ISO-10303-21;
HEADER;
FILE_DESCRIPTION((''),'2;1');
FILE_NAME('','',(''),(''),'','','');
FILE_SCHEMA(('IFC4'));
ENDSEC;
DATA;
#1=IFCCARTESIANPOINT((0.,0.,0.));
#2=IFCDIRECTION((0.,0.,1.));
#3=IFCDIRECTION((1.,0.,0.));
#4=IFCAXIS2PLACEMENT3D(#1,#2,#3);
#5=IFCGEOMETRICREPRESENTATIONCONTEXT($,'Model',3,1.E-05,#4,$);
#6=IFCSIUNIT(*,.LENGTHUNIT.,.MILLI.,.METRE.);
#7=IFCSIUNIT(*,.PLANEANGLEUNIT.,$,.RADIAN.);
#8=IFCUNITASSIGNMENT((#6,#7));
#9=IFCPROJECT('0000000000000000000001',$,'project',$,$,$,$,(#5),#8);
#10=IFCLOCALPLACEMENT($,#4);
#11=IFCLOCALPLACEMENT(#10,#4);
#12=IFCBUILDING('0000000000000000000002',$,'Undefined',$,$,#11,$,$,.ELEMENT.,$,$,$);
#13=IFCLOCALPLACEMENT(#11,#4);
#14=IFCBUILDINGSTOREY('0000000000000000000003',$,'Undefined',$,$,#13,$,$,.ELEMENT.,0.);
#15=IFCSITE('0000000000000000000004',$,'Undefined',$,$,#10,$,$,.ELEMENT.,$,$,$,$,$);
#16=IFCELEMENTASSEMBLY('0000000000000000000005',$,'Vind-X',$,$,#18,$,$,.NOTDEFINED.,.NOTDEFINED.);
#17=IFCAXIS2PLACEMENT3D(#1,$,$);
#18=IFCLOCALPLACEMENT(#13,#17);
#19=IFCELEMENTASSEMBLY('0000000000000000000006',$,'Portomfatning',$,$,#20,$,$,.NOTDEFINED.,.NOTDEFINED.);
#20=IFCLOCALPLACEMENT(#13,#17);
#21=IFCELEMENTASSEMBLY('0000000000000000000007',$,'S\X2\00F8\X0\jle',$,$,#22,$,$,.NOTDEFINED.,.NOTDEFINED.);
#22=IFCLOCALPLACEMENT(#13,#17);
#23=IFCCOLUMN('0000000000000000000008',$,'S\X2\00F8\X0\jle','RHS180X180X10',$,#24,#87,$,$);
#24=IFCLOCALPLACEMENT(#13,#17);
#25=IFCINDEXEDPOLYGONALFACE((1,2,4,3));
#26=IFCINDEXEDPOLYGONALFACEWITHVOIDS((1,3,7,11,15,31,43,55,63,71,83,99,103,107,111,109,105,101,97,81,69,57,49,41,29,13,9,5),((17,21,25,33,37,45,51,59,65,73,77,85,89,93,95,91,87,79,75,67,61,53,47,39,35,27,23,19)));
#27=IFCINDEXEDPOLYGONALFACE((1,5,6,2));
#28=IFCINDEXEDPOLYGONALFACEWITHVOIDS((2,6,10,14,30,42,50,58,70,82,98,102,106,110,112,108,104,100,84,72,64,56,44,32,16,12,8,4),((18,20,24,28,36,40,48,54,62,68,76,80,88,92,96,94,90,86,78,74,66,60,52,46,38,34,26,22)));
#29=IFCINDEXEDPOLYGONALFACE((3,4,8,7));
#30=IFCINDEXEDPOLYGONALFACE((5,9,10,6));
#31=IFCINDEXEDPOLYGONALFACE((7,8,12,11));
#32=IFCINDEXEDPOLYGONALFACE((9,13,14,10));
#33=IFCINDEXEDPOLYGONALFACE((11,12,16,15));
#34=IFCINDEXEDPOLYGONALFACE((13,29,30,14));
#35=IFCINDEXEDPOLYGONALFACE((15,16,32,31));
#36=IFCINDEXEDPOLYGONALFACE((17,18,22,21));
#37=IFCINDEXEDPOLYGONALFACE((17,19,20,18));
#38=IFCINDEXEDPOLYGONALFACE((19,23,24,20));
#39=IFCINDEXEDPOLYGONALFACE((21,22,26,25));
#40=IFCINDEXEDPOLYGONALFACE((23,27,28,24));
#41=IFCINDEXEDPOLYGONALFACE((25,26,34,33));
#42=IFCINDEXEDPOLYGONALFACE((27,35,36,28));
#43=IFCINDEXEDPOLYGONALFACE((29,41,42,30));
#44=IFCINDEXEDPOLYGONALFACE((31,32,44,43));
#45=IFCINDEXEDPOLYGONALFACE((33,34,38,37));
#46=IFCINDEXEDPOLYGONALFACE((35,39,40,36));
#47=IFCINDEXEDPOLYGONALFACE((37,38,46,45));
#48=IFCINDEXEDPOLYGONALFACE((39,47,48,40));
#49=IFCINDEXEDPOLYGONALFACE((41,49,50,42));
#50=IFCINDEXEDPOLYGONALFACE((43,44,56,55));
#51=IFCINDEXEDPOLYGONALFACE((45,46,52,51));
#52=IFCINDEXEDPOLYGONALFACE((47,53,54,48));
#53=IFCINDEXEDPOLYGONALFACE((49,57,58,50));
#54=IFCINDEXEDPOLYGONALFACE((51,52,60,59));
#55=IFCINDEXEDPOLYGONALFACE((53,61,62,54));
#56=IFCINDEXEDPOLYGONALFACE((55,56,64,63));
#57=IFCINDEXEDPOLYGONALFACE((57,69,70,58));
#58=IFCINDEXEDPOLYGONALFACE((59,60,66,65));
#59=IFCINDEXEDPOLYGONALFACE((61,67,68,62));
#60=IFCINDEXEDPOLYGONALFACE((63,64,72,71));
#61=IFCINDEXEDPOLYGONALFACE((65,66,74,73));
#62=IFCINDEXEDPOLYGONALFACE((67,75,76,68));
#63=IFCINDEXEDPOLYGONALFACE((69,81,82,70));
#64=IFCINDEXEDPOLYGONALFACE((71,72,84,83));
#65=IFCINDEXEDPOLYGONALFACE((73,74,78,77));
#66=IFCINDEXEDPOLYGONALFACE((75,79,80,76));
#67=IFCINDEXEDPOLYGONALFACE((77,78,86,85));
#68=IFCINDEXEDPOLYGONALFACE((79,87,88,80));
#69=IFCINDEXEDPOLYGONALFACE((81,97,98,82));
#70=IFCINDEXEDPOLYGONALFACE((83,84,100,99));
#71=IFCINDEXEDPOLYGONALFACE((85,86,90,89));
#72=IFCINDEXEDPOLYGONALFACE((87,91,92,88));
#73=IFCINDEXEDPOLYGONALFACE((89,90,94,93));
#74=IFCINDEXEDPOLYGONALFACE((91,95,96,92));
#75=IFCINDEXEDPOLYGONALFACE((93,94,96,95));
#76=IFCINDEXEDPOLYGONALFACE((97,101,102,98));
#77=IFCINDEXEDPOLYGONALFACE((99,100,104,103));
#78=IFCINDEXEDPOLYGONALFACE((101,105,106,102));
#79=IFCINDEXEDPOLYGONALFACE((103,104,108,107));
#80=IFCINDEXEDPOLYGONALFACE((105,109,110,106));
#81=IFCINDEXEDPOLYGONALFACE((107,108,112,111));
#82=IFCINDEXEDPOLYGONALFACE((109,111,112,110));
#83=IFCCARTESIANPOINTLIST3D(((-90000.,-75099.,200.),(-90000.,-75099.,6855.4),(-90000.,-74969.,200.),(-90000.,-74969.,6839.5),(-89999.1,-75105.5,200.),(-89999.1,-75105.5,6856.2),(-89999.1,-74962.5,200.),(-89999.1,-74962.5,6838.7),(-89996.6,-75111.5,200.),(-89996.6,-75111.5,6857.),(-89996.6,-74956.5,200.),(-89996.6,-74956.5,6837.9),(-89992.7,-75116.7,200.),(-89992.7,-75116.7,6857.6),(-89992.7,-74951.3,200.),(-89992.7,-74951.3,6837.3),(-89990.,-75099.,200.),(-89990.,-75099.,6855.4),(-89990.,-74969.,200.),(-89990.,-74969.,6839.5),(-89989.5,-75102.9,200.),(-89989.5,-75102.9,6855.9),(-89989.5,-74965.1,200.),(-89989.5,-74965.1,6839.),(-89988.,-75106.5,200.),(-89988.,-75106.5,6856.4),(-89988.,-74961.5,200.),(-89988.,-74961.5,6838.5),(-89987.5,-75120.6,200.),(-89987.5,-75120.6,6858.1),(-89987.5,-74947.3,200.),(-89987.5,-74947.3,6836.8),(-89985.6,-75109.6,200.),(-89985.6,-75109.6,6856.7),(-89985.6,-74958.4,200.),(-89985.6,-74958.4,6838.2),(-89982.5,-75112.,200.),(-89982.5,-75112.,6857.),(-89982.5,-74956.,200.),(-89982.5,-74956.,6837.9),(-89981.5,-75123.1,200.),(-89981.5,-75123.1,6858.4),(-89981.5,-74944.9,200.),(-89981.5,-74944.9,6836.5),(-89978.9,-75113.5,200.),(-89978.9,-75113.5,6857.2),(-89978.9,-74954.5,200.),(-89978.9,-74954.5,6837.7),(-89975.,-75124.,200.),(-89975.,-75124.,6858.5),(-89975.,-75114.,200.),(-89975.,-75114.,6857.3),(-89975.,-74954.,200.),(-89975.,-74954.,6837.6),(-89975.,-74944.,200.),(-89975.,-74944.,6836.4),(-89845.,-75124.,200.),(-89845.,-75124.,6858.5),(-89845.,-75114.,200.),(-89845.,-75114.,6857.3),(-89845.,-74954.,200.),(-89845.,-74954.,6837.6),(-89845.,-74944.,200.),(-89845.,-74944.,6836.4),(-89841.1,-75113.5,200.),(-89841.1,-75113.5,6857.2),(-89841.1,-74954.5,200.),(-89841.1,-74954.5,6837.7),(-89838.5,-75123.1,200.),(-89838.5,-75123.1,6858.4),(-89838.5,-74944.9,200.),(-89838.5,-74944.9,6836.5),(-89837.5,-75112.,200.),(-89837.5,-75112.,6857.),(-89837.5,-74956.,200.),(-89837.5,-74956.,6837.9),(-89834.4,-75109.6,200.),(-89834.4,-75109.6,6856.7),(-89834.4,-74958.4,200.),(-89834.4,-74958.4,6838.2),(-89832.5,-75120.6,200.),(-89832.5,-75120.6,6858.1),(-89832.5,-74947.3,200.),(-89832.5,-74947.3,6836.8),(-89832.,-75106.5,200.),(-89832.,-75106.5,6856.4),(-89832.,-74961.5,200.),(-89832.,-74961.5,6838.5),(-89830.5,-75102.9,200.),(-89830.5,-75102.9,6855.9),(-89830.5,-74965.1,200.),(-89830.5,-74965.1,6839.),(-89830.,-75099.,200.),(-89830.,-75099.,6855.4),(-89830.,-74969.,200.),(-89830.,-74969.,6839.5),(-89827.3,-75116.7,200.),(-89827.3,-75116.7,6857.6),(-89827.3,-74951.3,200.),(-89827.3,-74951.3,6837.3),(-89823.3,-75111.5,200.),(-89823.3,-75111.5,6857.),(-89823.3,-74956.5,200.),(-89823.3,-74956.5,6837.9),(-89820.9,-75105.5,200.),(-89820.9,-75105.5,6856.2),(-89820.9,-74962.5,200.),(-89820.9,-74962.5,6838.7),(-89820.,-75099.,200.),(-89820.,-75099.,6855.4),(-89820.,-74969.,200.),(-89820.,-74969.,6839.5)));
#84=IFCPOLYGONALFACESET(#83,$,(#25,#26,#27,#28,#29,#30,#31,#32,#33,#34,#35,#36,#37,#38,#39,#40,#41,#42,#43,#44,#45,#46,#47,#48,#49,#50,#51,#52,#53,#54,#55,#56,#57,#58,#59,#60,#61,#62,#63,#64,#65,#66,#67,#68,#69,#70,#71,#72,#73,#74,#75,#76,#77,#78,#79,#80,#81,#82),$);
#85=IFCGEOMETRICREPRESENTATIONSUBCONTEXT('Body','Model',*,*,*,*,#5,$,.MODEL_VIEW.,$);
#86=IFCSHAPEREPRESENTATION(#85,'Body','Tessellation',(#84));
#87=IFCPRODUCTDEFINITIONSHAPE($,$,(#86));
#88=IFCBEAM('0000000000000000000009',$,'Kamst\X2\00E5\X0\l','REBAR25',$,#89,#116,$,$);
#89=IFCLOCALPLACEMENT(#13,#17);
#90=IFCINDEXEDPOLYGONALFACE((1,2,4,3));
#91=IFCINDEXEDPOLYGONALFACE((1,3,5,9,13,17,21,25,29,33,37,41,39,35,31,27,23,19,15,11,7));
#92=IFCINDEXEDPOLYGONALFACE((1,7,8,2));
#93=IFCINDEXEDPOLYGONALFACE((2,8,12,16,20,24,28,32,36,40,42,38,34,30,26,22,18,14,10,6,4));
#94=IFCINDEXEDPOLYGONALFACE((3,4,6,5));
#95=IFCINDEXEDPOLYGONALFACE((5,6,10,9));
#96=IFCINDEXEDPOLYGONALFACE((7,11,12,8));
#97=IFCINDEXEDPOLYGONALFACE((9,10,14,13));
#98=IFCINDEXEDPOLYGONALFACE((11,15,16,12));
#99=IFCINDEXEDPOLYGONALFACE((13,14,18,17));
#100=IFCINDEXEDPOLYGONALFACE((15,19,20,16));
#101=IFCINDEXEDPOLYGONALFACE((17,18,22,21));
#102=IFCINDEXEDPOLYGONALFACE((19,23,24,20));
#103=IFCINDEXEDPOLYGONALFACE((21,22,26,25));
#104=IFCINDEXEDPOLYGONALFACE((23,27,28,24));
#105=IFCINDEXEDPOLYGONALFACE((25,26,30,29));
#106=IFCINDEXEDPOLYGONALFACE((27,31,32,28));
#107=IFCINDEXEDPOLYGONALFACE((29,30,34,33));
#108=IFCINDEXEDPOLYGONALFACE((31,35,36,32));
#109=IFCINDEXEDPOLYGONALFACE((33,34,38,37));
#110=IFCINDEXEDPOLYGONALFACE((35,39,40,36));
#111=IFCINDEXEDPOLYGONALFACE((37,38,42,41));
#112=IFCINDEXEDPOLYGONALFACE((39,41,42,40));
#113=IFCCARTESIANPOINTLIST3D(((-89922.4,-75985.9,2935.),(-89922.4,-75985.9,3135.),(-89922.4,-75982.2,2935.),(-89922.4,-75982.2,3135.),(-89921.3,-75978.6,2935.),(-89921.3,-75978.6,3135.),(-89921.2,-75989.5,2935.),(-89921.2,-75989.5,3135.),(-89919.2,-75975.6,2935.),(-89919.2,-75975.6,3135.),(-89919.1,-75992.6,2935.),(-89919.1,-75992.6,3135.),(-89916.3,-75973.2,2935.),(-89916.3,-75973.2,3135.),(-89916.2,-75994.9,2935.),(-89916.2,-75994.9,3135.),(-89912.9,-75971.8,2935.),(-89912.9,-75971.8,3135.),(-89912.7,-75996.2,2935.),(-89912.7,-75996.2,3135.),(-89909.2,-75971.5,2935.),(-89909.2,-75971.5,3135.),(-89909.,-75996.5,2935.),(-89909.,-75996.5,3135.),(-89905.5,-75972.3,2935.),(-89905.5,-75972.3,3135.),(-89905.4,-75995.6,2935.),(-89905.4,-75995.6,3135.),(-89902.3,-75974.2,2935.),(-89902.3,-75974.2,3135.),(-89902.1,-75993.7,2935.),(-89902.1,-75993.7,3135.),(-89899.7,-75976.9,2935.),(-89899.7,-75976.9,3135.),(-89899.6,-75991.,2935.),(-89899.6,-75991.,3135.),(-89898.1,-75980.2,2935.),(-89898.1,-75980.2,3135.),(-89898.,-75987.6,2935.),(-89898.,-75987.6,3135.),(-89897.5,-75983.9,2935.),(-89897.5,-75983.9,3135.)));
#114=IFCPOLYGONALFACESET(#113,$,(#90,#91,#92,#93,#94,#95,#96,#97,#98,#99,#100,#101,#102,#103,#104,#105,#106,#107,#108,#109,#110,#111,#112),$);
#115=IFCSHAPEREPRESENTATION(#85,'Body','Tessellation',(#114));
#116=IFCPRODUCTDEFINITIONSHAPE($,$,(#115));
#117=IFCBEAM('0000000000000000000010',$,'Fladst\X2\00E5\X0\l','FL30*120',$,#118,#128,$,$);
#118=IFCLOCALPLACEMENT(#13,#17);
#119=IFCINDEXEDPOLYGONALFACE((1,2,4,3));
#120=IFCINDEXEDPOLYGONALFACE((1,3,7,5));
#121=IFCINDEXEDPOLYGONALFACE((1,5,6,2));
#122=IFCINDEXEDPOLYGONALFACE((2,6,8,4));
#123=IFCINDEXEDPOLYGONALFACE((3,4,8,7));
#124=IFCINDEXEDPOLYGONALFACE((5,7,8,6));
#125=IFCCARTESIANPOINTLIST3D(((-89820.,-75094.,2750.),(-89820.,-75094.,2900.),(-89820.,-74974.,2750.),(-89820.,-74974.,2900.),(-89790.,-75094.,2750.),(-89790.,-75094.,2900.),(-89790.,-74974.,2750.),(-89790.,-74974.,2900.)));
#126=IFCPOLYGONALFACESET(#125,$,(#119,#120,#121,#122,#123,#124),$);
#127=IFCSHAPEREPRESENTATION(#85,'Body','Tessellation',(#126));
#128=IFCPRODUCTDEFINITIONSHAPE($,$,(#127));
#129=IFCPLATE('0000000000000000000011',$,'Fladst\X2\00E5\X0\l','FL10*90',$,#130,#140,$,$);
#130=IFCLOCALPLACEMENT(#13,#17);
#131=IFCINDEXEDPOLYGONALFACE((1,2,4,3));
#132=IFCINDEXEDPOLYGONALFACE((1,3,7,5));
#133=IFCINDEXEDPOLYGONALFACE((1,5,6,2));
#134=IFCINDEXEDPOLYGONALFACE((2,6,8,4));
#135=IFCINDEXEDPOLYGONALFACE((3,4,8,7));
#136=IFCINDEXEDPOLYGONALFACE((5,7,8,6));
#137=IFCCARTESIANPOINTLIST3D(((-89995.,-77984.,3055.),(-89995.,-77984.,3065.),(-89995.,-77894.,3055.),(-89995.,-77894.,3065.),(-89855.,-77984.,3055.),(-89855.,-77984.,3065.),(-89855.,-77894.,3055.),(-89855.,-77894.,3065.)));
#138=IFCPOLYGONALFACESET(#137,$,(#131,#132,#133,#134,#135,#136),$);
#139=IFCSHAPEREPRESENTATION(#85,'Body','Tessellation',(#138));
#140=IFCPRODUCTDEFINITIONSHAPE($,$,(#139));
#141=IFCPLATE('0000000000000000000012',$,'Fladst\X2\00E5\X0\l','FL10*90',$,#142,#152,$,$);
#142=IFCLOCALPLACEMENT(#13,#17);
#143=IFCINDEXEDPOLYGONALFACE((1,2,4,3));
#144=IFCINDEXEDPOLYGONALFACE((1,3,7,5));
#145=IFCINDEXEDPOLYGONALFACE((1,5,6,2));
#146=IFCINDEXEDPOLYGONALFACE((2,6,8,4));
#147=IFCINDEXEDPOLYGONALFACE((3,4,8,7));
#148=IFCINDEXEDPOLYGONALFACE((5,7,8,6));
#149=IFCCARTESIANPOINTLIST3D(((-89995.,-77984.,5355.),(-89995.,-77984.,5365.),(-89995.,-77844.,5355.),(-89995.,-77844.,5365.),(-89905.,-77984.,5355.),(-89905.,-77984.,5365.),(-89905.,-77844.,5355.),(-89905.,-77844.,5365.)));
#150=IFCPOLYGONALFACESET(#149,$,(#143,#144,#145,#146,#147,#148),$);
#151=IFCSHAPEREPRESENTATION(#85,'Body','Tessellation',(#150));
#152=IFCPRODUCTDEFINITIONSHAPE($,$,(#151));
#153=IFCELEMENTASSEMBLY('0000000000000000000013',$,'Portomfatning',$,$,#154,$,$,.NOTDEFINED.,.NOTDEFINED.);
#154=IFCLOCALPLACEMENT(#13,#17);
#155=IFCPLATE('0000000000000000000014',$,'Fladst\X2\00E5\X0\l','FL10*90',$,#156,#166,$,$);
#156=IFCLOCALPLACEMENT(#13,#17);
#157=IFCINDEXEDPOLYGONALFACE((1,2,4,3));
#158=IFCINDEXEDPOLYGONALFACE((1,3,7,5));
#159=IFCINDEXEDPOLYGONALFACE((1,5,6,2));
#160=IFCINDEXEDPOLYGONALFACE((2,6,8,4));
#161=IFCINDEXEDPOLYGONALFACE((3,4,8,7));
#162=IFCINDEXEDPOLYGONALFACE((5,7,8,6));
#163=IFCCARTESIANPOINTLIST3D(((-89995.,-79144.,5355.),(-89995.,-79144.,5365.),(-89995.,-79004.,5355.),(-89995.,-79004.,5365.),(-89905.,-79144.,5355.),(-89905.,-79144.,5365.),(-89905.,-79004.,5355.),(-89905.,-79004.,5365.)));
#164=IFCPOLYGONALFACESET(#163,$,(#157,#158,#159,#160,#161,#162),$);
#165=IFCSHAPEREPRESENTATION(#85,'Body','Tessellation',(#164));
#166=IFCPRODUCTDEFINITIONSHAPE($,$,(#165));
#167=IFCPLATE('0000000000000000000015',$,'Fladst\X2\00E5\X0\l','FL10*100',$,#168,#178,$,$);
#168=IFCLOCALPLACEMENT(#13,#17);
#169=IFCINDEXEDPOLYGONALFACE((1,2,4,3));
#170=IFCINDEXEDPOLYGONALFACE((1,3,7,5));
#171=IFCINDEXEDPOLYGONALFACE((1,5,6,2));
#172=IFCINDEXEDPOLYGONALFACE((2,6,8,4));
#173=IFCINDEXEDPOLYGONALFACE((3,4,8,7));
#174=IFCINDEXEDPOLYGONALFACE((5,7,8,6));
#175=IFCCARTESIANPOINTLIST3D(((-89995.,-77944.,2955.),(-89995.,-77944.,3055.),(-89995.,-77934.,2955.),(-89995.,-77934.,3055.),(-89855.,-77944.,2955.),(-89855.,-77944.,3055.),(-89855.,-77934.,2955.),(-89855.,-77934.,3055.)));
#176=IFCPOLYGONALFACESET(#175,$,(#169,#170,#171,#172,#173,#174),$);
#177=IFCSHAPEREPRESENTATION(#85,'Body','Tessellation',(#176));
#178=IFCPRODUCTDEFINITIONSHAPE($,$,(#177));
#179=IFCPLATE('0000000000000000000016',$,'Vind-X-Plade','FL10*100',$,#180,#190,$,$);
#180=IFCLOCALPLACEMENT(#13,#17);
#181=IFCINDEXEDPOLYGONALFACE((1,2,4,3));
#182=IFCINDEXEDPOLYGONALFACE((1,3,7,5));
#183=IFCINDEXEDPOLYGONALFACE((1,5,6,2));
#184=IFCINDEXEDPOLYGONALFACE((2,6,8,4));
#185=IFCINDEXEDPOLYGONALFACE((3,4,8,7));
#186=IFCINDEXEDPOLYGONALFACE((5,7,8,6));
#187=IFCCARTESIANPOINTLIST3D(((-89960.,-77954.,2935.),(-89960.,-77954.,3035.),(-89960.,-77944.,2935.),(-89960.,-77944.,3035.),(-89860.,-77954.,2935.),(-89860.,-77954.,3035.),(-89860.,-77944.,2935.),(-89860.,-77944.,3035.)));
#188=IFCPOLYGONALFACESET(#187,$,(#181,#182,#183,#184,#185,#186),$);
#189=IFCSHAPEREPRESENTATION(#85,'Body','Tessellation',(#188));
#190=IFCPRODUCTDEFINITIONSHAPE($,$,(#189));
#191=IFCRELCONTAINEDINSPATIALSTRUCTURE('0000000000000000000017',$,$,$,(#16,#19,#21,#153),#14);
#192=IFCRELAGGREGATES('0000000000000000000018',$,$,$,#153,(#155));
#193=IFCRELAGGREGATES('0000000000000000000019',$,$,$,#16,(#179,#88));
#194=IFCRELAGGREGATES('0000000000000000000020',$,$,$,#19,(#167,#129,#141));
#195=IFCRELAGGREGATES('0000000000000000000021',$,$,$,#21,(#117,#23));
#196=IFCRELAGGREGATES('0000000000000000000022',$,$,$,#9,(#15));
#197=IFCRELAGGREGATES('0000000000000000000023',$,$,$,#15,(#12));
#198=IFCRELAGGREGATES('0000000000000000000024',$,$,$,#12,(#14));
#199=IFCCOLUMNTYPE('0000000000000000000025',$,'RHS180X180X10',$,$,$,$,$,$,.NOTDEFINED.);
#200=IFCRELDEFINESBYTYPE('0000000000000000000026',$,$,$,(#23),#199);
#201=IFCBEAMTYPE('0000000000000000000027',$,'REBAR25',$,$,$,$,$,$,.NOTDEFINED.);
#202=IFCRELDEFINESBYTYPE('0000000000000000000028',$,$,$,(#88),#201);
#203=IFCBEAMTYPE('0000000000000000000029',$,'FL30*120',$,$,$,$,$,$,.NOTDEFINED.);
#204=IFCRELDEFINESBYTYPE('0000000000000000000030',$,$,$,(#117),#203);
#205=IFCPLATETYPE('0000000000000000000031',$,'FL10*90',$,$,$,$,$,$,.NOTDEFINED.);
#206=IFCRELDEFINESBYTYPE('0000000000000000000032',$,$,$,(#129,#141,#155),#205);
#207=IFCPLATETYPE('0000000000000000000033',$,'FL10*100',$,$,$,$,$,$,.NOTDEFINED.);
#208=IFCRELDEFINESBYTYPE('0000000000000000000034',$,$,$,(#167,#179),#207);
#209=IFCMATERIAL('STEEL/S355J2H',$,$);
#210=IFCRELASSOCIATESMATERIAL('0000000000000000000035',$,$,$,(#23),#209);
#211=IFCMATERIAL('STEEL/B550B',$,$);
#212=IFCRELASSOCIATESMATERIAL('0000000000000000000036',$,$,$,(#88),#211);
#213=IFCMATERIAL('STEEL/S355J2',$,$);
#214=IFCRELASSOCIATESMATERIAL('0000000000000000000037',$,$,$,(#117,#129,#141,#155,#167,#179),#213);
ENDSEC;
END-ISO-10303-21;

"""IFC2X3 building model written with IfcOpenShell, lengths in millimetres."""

from ifc_helpers import new_model, si_unit, frame, origin_with_axes, origin_2d_with_axis, place, context, subcontext, project, spatial, polyline, rectangle, hollow_rectangle, circle, outline, extrude, clip, halfspace, material, type_object, element, aggregate, save


model = new_model("IFC2X3")

# Units and contexts
model_context = context("Model", 3, precision=1e-05, world=origin_with_axes())
body_context = subcontext(model_context, "Body", "Model", "MODEL_VIEW")
ifc_project = project(units=[si_unit("LENGTHUNIT", "METRE", prefix="MILLI"), si_unit("PLANEANGLEUNIT", "RADIAN")], contexts=[model_context])

# Site, building, storey
site_placement = place(None, origin_with_axes())
site = spatial("IfcSite", under=ifc_project, at=site_placement, Name="Undefined", CompositionType="ELEMENT")
building_placement = place(site_placement, origin_with_axes())
building = spatial("IfcBuilding", under=site, at=building_placement, Name="Undefined", CompositionType="ELEMENT")
storey_placement = place(building_placement, origin_with_axes())
storey = spatial("IfcBuildingStorey", under=building, at=storey_placement, Name="Undefined", CompositionType="ELEMENT", Elevation=0.0)

# Shared definitions
ifc_material_1 = material(Name="STEEL/B550B")

# Element assembly
assembly_1_placement = place(storey_placement, origin_with_axes())
assembly_1 = element("IfcElementAssembly", 1, at=assembly_1_placement, inside=storey, Name="Vind-X", AssemblyPlace="NOTDEFINED", PredefinedType="NOTDEFINED")

# Element assemblies, column
assembly_2_placement = place(storey_placement, origin_with_axes())
assembly_2 = element("IfcElementAssembly", 2, at=assembly_2_placement, inside=storey, Name="Portomfatning", AssemblyPlace="NOTDEFINED", PredefinedType="NOTDEFINED")
ifc_material_2 = material(Name="STEEL/S355J2H")
assembly_3_placement = place(storey_placement, origin_with_axes())
assembly_3 = element("IfcElementAssembly", 3, at=assembly_3_placement, inside=storey, Name="Søjle", AssemblyPlace="NOTDEFINED", PredefinedType="NOTDEFINED")
column_type_1 = type_object("IfcColumnType", Name="RHS180X180X10", PredefinedType="NOTDEFINED")
column_1_placement = place(assembly_3_placement, frame((-89910.0, -75034.0, 200.0), z_axis=(0.0, 0.0, 1.0), x_axis=(0.0, 1.0, 0.0)))
column_1 = element("IfcColumn", 4, at=column_1_placement, type_object=column_type_1, material=ifc_material_2, Name="Søjle", Description="RHS180X180X10", context=body_context, shape_type="Clipping", body=[
    clip(extrude(hollow_rectangle(XDim=180.0, YDim=180.0, WallThickness=10.0, InnerFilletRadius=15.0, OuterFilletRadius=25.0, at=origin_2d_with_axis()), frame((0.0, 0.0, 6658.6), z_axis=(0.0, 0.0, -1.0), x_axis=(0.0, 1.0, 0.0)), (0.0, 0.0, 1.0), 6658.6), halfspace(frame((90.0, 0.0, 6636.4), z_axis=(-0.121869, 0.0, -0.992546), x_axis=(0.0, 1.0, 0.0)), True)),
])

# Beam
beam_type_1 = type_object("IfcBeamType", Name="REBAR25", PredefinedType="NOTDEFINED")
beam_1_placement = place(assembly_1_placement, frame((-89910.0, -75984.0, 3135.0), z_axis=(-0.862746, -0.505638, 0.0), x_axis=(0.0, 0.0, -1.0)))
beam_1 = element("IfcBeam", 5, at=beam_1_placement, type_object=beam_type_1, material=ifc_material_1, Name="Kamstål", Description="REBAR25", context=body_context, shape_type="SweptSolid", body=[
    extrude(circle(Radius=12.5, at=origin_2d_with_axis()), frame((200.0, 0.0, 0.0), z_axis=(-1.0, 0.0, 0.0), x_axis=(0.0, -1.0, 0.0)), (0.0, 0.0, 1.0), 200.0),
])

# Beam
ifc_material_3 = material(Name="STEEL/S355J2")
beam_type_2 = type_object("IfcBeamType", Name="FL30*120", PredefinedType="NOTDEFINED")
beam_2_placement = place(assembly_3_placement, frame((-89805.0, -75034.0, 2900.0), z_axis=(0.0, -1.0, 0.0), x_axis=(0.0, 0.0, -1.0)))
beam_2 = element("IfcBeam", 6, at=beam_2_placement, type_object=beam_type_2, material=ifc_material_3, Name="Fladstål", Description="FL30*120", context=body_context, shape_type="SweptSolid", body=[
    extrude(rectangle(XDim=30.0, YDim=120.0, at=origin_2d_with_axis()), frame((150.0, 0.0, 0.0), z_axis=(-1.0, 0.0, 0.0), x_axis=(0.0, -1.0, 0.0)), (0.0, 0.0, 1.0), 150.0),
])

# Plates
plate_type_1 = type_object("IfcPlateType", Name="FL10*90", PredefinedType="NOTDEFINED")
plate_1_placement = place(assembly_2_placement, frame((-89995.0, -77984.0, 3060.0), z_axis=(0.0, 0.0, 1.0), x_axis=(1.0, 0.0, 0.0)))
plate_1 = element("IfcPlate", 7, at=plate_1_placement, type_object=plate_type_1, material=ifc_material_3, Name="Fladstål", Description="FL10*90", context=body_context, shape_type="SweptSolid", body=[
    extrude(outline(polyline([(0.0, 0.0), (140.0, 0.0), (140.0, 90.0), (0.0, 90.0), (0.0, 0.0)])), frame((0.0, 0.0, -5.0), z_axis=(0.0, 0.0, 1.0), x_axis=(1.0, 0.0, 0.0)), (0.0, 0.0, 1.0), 10.0),
])
plate_2_placement = place(assembly_2_placement, frame((-89950.0, -77984.0, 5360.0), z_axis=(0.0, 0.0, -1.0), x_axis=(0.0, 1.0, 0.0)))
plate_2 = element("IfcPlate", 8, at=plate_2_placement, type_object=plate_type_1, material=ifc_material_3, Name="Fladstål", Description="FL10*90", context=body_context, shape_type="SweptSolid", body=[
    extrude(outline(polyline([(0.0, -45.0), (0.0, 45.0), (140.0, 45.0), (140.0, -45.0), (0.0, -45.0)])), frame((0.0, 0.0, -5.0), z_axis=(0.0, 0.0, 1.0), x_axis=(1.0, 0.0, 0.0)), (0.0, 0.0, 1.0), 10.0),
])

# Element assembly, plate
assembly_4_placement = place(storey_placement, origin_with_axes())
assembly_4 = element("IfcElementAssembly", 9, at=assembly_4_placement, inside=storey, Name="Portomfatning", AssemblyPlace="NOTDEFINED", PredefinedType="NOTDEFINED")
plate_3_placement = place(assembly_4_placement, frame((-89950.0, -79004.0, 5360.0), z_axis=(0.0, 0.0, -1.0), x_axis=(0.0, -1.0, 0.0)))
plate_3 = element("IfcPlate", 10, at=plate_3_placement, type_object=plate_type_1, material=ifc_material_3, Name="Fladstål", Description="FL10*90", context=body_context, shape_type="SweptSolid", body=[
    extrude(outline(polyline([(0.0, -45.0), (0.0, 45.0), (140.0, 45.0), (140.0, -45.0), (0.0, -45.0)])), frame((0.0, 0.0, -5.0), z_axis=(0.0, 0.0, 1.0), x_axis=(1.0, 0.0, 0.0)), (0.0, 0.0, 1.0), 10.0),
])
aggregate(assembly_4, [plate_3])

# Plates
plate_type_2 = type_object("IfcPlateType", Name="FL10*100", PredefinedType="NOTDEFINED")
plate_4_placement = place(assembly_2_placement, frame((-89925.0, -77939.0, 2955.0), z_axis=(0.0, 1.0, 0.0), x_axis=(0.0, 0.0, 1.0)))
plate_4 = element("IfcPlate", 11, at=plate_4_placement, type_object=plate_type_2, material=ifc_material_3, Name="Fladstål", Description="FL10*100", context=body_context, shape_type="SweptSolid", body=[
    extrude(outline(polyline([(0.0, -70.0), (0.0, 70.0), (100.0, 70.0), (100.0, -70.0), (0.0, -70.0)])), frame((0.0, 0.0, -5.0), z_axis=(0.0, 0.0, 1.0), x_axis=(1.0, 0.0, 0.0)), (0.0, 0.0, 1.0), 10.0),
])
plate_5_placement = place(assembly_1_placement, frame((-89960.0, -77949.0, 2935.0), z_axis=(0.0, -1.0, 0.0), x_axis=(1.0, 0.0, 0.0)))
plate_5 = element("IfcPlate", 12, at=plate_5_placement, type_object=plate_type_2, material=ifc_material_3, Name="Vind-X-Plade", Description="FL10*100", context=body_context, shape_type="SweptSolid", body=[
    extrude(outline(polyline([(0.0, 0.0), (100.0, 0.0), (100.0, 100.0), (0.0, 100.0), (0.0, 0.0)])), frame((0.0, 0.0, -5.0), z_axis=(0.0, 0.0, 1.0), x_axis=(1.0, 0.0, 0.0)), (0.0, 0.0, 1.0), 10.0),
])

aggregate(assembly_1, [plate_5, beam_1])
aggregate(assembly_2, [plate_4, plate_1, plate_2])
aggregate(assembly_3, [beam_2, column_1])

save(model, "model.ifc")
